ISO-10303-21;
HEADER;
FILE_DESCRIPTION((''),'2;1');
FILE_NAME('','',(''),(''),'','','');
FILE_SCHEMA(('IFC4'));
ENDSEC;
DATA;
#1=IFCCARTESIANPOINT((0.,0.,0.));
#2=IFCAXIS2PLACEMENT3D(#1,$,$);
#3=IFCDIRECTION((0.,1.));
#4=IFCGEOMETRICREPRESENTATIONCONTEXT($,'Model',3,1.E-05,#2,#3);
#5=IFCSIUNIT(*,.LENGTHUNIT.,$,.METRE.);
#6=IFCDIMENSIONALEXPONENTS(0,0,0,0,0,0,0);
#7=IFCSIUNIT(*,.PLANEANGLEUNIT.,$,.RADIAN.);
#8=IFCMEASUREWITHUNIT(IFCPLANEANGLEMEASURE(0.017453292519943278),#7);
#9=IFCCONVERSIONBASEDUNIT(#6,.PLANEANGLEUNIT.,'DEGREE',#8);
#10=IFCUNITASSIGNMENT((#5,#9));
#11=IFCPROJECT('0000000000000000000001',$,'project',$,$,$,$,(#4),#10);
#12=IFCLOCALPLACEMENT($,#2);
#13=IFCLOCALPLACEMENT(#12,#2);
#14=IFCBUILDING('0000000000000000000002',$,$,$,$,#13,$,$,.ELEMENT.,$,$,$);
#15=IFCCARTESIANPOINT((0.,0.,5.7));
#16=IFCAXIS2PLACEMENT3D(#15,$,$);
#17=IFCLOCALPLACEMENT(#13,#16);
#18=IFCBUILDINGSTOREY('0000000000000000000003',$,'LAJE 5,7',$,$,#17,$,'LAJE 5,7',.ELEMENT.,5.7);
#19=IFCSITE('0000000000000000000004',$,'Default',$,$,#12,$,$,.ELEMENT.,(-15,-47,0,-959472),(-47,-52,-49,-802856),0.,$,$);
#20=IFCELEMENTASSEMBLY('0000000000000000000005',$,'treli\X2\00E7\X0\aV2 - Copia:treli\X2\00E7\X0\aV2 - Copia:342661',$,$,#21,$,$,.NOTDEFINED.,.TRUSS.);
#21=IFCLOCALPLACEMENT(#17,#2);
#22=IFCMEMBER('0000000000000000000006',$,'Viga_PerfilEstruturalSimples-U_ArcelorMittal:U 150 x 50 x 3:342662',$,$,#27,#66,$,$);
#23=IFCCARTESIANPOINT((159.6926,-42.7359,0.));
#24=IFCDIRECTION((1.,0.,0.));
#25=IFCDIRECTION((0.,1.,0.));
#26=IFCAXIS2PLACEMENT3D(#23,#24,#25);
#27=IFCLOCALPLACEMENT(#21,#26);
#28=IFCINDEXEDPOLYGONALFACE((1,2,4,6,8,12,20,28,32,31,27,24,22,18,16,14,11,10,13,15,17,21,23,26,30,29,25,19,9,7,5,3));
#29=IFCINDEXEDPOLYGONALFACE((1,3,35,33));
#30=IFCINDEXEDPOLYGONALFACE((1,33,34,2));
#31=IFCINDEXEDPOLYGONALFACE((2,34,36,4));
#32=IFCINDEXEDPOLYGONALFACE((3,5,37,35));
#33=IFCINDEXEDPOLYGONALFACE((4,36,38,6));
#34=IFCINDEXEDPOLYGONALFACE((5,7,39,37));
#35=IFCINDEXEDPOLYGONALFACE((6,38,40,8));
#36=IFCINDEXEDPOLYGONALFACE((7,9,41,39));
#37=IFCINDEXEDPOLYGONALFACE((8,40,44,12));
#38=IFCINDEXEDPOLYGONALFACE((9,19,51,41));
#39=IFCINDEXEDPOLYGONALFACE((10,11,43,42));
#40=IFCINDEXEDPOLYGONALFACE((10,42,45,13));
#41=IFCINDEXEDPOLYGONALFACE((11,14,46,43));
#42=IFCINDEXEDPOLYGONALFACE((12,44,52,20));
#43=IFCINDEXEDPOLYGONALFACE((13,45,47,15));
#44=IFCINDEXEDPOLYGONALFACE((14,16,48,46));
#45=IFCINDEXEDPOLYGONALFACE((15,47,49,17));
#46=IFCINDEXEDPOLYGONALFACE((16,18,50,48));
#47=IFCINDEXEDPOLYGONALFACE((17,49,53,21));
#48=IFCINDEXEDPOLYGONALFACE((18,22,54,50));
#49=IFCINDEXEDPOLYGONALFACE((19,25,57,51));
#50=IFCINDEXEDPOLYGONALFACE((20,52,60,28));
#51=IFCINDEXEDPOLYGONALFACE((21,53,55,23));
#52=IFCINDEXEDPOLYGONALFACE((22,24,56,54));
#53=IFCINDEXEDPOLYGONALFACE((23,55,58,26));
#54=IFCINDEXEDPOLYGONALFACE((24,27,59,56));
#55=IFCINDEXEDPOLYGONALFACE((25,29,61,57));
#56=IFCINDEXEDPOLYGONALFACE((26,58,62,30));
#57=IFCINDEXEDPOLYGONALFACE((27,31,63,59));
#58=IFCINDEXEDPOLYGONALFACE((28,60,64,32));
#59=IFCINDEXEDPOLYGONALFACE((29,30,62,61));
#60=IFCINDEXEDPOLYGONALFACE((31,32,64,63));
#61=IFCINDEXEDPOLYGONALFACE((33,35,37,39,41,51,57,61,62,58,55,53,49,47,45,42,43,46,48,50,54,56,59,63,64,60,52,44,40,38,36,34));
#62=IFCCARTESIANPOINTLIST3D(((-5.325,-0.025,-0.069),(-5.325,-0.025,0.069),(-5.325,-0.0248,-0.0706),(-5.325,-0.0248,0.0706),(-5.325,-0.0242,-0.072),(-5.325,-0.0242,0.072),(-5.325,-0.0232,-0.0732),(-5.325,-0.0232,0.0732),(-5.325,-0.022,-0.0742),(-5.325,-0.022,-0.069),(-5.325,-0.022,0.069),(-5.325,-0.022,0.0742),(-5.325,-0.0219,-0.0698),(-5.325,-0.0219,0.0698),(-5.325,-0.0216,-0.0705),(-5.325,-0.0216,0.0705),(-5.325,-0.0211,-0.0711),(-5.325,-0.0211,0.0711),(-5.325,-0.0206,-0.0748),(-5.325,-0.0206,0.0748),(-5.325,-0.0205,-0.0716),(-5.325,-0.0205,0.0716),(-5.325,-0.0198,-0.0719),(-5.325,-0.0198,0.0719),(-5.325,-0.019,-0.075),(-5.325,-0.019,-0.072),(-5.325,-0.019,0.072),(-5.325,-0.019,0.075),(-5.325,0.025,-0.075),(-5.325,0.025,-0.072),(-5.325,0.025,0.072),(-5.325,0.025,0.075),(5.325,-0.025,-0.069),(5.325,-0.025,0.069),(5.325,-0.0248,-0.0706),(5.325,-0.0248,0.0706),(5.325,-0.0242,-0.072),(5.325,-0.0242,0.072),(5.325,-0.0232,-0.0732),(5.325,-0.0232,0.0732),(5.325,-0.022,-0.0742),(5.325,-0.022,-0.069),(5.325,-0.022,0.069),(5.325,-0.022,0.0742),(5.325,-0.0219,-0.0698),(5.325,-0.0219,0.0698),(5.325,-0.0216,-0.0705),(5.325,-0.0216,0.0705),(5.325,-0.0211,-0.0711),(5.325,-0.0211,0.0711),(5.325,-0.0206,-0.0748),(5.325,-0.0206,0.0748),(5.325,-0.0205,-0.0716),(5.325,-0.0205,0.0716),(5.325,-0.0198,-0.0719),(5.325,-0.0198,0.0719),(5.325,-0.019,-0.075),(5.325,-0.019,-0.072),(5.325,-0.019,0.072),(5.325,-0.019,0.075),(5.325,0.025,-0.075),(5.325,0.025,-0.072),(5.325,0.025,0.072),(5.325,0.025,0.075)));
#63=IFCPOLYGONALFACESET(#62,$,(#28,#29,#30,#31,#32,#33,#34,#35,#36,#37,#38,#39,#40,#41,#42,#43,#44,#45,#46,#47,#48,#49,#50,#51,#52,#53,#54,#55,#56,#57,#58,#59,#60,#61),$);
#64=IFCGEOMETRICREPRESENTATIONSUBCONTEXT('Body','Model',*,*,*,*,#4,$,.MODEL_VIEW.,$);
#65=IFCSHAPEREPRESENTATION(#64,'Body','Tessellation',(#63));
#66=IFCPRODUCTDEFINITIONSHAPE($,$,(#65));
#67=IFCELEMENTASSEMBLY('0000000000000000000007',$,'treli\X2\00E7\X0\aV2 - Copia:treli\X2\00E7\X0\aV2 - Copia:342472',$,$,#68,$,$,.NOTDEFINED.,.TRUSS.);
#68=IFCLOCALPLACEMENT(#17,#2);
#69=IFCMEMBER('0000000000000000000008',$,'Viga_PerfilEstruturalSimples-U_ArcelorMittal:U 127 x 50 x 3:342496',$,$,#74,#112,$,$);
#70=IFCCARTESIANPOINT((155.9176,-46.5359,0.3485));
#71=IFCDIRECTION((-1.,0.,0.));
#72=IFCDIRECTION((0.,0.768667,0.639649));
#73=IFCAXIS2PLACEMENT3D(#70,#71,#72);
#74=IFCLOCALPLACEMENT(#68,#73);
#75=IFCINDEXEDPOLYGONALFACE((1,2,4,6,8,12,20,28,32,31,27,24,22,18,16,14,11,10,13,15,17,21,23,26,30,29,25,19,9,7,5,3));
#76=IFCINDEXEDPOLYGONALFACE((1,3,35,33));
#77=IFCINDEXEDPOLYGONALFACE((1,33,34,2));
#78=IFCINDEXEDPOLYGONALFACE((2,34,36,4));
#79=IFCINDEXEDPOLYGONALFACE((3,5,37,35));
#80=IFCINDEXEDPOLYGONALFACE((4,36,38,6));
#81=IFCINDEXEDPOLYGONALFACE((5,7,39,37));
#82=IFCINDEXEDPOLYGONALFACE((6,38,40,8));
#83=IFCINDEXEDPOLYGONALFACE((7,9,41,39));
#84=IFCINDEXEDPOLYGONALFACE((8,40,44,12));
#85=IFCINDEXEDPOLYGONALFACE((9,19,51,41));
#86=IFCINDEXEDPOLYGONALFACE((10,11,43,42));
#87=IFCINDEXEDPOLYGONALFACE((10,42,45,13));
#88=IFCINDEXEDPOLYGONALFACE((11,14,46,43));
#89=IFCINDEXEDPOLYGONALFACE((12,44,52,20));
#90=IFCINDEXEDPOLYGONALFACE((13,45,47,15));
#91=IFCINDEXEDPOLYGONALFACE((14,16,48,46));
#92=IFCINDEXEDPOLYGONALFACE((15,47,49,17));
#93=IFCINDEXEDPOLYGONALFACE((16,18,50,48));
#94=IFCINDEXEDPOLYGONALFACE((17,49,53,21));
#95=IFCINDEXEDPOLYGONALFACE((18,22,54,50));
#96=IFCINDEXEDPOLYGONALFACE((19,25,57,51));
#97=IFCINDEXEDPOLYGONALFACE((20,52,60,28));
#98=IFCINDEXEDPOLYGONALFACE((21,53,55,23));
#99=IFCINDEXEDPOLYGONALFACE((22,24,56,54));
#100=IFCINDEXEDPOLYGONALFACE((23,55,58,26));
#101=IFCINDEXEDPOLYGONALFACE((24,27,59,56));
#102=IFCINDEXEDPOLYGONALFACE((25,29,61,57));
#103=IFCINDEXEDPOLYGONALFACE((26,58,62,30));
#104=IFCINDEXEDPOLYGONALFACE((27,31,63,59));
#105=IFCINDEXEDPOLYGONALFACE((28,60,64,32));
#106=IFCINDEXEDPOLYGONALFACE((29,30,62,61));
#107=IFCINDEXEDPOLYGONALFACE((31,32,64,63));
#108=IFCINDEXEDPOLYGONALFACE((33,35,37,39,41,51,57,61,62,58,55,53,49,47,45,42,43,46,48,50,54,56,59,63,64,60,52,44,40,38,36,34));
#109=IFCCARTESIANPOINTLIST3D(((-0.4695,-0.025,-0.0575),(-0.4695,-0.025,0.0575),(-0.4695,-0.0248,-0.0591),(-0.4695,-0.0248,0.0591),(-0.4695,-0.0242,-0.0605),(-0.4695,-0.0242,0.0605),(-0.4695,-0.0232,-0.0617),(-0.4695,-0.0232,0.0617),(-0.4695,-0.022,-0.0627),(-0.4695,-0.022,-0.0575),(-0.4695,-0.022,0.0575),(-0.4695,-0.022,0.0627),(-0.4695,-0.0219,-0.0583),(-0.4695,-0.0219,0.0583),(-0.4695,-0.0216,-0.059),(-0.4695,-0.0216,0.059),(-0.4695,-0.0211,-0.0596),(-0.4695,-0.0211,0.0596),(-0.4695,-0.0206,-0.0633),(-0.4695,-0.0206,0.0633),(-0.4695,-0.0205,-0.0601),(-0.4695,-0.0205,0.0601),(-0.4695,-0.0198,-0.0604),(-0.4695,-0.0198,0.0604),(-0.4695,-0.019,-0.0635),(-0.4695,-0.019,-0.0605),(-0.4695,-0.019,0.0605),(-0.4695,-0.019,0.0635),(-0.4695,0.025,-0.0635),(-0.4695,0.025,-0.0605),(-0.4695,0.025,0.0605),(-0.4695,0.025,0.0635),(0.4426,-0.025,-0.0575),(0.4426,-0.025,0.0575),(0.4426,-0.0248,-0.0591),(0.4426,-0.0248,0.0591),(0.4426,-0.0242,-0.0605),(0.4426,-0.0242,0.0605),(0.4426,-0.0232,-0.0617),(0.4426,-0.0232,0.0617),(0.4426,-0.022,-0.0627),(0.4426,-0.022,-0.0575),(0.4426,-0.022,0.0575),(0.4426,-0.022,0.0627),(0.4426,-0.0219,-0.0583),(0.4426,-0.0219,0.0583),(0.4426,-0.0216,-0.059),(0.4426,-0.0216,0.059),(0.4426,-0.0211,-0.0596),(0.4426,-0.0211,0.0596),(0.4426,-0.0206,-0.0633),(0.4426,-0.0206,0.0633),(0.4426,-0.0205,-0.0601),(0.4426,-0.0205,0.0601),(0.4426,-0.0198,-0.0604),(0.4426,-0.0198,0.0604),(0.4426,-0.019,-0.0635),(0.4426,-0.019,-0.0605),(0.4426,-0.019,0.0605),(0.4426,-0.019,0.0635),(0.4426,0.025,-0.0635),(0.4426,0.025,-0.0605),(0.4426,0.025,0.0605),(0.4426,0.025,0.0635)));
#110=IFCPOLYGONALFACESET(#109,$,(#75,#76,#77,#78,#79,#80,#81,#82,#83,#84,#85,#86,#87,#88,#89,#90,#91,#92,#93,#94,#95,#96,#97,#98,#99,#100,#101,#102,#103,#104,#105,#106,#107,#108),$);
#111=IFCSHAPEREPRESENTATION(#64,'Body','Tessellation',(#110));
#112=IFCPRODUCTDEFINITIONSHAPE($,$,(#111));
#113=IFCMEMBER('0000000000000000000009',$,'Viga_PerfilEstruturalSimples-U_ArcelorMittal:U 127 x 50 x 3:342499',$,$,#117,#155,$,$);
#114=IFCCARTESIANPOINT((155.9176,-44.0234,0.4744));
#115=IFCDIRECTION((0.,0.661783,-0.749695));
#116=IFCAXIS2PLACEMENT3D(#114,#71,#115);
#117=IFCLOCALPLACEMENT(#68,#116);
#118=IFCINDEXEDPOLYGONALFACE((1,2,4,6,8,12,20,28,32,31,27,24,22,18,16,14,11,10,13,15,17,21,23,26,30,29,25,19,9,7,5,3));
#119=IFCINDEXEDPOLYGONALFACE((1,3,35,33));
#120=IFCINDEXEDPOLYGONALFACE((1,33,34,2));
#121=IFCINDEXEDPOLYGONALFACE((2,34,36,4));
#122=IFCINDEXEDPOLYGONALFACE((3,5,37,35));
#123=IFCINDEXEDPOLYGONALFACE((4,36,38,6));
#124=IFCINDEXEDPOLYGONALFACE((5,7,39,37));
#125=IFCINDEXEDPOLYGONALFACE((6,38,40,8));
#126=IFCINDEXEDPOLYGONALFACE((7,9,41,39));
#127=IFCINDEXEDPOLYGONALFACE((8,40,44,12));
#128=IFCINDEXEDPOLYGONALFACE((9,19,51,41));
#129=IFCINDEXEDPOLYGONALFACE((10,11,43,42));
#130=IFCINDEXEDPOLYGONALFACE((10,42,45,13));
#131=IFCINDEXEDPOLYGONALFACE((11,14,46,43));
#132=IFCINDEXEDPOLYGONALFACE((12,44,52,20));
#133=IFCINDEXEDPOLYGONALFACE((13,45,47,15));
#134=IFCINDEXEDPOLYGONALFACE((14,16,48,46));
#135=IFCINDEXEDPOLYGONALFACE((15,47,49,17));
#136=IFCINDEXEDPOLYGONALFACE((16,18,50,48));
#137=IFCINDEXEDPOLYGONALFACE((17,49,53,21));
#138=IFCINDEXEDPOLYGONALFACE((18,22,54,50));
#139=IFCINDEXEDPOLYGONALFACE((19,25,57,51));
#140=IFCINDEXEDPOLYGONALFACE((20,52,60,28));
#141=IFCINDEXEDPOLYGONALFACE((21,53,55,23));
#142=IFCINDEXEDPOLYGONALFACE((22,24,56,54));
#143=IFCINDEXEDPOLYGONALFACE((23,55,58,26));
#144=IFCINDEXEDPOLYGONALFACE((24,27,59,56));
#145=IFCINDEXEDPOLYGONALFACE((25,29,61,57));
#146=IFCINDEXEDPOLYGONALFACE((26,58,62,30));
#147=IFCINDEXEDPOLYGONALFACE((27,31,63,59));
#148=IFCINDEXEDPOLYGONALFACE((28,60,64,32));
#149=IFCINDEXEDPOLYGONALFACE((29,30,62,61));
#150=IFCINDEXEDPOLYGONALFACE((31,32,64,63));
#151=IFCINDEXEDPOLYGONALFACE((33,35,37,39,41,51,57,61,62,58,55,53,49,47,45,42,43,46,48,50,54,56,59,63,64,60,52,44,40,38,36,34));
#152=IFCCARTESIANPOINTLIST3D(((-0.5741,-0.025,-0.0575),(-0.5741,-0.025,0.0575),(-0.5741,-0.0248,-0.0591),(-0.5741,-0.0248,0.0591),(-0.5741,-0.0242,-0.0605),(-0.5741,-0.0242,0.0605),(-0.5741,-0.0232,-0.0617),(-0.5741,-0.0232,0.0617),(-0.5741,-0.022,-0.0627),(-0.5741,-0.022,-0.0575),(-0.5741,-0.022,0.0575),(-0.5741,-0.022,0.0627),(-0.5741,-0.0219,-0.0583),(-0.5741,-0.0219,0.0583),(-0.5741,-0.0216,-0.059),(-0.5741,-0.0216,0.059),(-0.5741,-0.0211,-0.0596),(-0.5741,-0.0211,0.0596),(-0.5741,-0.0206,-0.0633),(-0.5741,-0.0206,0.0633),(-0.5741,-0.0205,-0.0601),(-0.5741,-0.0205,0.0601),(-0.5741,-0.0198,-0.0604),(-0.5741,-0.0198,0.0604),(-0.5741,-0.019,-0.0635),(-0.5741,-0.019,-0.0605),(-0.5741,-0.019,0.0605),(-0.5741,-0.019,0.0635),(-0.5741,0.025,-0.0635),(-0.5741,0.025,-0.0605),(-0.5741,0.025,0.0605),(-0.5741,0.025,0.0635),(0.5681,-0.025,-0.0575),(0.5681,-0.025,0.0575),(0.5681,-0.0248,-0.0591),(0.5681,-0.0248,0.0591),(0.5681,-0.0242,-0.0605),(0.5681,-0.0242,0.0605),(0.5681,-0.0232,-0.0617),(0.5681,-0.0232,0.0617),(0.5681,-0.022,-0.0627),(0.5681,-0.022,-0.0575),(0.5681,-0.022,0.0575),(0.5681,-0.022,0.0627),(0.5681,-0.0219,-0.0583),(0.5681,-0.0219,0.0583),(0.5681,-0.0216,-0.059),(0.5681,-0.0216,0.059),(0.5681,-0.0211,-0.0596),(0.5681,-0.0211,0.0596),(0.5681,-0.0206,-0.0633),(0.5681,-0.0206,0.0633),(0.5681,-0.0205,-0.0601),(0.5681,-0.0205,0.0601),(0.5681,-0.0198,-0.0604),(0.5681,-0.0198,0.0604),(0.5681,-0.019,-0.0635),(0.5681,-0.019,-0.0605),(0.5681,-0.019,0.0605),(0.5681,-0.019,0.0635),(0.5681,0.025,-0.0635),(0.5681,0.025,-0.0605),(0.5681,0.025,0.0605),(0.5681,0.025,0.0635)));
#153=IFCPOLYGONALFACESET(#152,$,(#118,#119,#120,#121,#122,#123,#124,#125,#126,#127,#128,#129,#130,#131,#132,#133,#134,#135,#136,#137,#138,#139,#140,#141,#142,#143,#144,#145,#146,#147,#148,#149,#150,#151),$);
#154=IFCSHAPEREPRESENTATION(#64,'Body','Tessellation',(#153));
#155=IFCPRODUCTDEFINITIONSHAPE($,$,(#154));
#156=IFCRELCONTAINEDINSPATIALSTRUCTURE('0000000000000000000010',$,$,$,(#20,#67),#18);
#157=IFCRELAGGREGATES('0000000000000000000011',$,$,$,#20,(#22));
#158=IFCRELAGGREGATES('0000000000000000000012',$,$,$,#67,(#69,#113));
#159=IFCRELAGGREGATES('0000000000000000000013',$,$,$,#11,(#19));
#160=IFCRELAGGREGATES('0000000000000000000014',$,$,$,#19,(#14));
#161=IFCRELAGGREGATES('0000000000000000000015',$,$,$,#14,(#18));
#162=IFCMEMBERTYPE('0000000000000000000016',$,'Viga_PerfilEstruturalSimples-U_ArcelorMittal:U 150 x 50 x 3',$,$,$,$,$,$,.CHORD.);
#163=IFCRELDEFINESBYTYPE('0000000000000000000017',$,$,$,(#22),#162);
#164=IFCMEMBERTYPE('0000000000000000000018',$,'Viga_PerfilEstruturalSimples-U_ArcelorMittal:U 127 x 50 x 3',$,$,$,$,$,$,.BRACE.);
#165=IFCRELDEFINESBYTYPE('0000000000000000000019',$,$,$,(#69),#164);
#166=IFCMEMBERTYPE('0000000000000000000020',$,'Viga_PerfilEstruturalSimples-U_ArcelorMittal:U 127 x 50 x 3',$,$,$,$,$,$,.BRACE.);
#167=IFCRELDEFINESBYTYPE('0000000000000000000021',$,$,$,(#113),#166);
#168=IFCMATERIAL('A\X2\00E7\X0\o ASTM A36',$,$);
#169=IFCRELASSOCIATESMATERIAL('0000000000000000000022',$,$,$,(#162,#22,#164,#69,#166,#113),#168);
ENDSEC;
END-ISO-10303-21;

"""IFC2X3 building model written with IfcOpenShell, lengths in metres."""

from ifc_helpers import new_model, entity, si_unit, converted_unit, direction, frame, frame_2d, origin, place, context, subcontext, project, spatial, polyline, circle_curve, parameter, trimmed, segment, composite_curve, outline, extrude, source, transform, mapped, material, type_object, type_shapes, element, aggregate, save


model = new_model("IFC2X3")

# Units and contexts
model_context = context("Model", 3, precision=1e-05, world=origin(), true_north=direction((0.0, 1.0)))
body_context = subcontext(model_context, "Body", "Model", "MODEL_VIEW")
ifc_project = project(units=[si_unit("LENGTHUNIT", "METRE"), converted_unit("PLANEANGLEUNIT", "DEGREE", entity("IfcPlaneAngleMeasure", 0.017453292519943278), si_unit("PLANEANGLEUNIT", "RADIAN"), dimensions=[0, 0, 0, 0, 0, 0, 0])], contexts=[model_context])

# Site, building, storey
site_placement = place(None, origin())
site = spatial("IfcSite", under=ifc_project, at=site_placement, Name="Default", CompositionType="ELEMENT", RefLatitude=(-15, -47, 0, -959472), RefLongitude=(-47, -52, -49, -802856), RefElevation=0.0)
building_placement = place(site_placement, origin())
building = spatial("IfcBuilding", under=site, at=building_placement, CompositionType="ELEMENT")
storey_placement = place(building_placement, frame((0.0, 0.0, 5.7)))
storey = spatial("IfcBuildingStorey", under=building, at=storey_placement, Name="LAJE 5,7", LongName="LAJE 5,7", CompositionType="ELEMENT", Elevation=5.7)

# Element assemblies, members
assembly_1_placement = place(storey_placement, origin())
assembly_1 = element("IfcElementAssembly", 1, at=assembly_1_placement, inside=storey, Name="treliçaV2 - Copia:treliçaV2 - Copia:342661", AssemblyPlace="NOTDEFINED", PredefinedType="TRUSS")
ifc_material = material(Name="Aço ASTM A36")
member_type_1 = type_object("IfcMemberType", Name="Viga_PerfilEstruturalSimples-U_ArcelorMittal:U 150 x 50 x 3", PredefinedType="CHORD", material=ifc_material)
shared_shape_1 = source(origin(), body_context, "Body", "SweptSolid", [
    extrude(outline(composite_curve([segment(polyline([(-0.069, -0.0192), (0.069, -0.0192)]), True, "CONTINUOUS"), segment(trimmed(circle_curve(frame_2d((0.069, -0.0132), x_axis=(0.0, 1.0)), 0.006), [parameter(180.0)], [parameter(270.0)], True, "PARAMETER"), True, "CONTINUOUS"), segment(polyline([(0.075, -0.0132), (0.075, 0.0308)]), True, "CONTINUOUS"), segment(polyline([(0.075, 0.0308), (0.072, 0.0308)]), True, "CONTINUOUS"), segment(polyline([(0.072, 0.0308), (0.072, -0.0132)]), True, "CONTINUOUS"), segment(trimmed(circle_curve(frame_2d((0.069, -0.0132), x_axis=(0.0, 1.0)), 0.003), [parameter(180.0)], [parameter(270.0)], True, "PARAMETER"), False, "CONTINUOUS"), segment(polyline([(0.069, -0.0162), (-0.069, -0.0162)]), True, "CONTINUOUS"), segment(trimmed(circle_curve(frame_2d((-0.069, -0.0132), x_axis=(0.0, 1.0)), 0.003), [parameter(90.0)], [parameter(180.0)], True, "PARAMETER"), False, "CONTINUOUS"), segment(polyline([(-0.072, -0.0132), (-0.072, 0.0308)]), True, "CONTINUOUS"), segment(polyline([(-0.072, 0.0308), (-0.075, 0.0308)]), True, "CONTINUOUS"), segment(polyline([(-0.075, 0.0308), (-0.075, -0.0132)]), True, "CONTINUOUS"), segment(trimmed(circle_curve(frame_2d((-0.069, -0.0132), x_axis=(0.0, 1.0)), 0.006), [parameter(90.0)], [parameter(180.0)], True, "PARAMETER"), True, "CONTINUOUS")], self_intersect=False)), frame((-5.325, -0.0058, 0.0), z_axis=(1.0, 0.0, 0.0), x_axis=(0.0, 0.0, -1.0)), (0.0, 0.0, 1.0), 10.65),
])
type_shapes(member_type_1, [shared_shape_1])
member_1_placement = place(assembly_1_placement, frame((159.6926, -42.7359, 0.0), z_axis=(1.0, 0.0, 0.0), x_axis=(0.0, 1.0, 0.0)))
member_1 = element("IfcMember", 2, at=member_1_placement, type_object=member_type_1, material=ifc_material, Name="Viga_PerfilEstruturalSimples-U_ArcelorMittal:U 150 x 50 x 3:342662", context=body_context, shape_type="MappedRepresentation", body=[
    mapped(shared_shape_1, transform((0.0, 0.0, 0.0), scale=1.0)),
])
aggregate(assembly_1, [member_1])
assembly_2_placement = place(storey_placement, origin())
assembly_2 = element("IfcElementAssembly", 3, at=assembly_2_placement, inside=storey, Name="treliçaV2 - Copia:treliçaV2 - Copia:342472", AssemblyPlace="NOTDEFINED", PredefinedType="TRUSS")
member_type_2 = type_object("IfcMemberType", Name="Viga_PerfilEstruturalSimples-U_ArcelorMittal:U 127 x 50 x 3", PredefinedType="BRACE", material=ifc_material)
shared_shape_2 = source(origin(), body_context, "Body", "SweptSolid", [
    extrude(outline(composite_curve([segment(polyline([(-0.0575, -0.0192), (0.0575, -0.0192)]), True, "CONTINUOUS"), segment(trimmed(circle_curve(frame_2d((0.0575, -0.0132), x_axis=(0.0, 1.0)), 0.006), [parameter(180.0)], [parameter(270.0)], True, "PARAMETER"), True, "CONTINUOUS"), segment(polyline([(0.0635, -0.0132), (0.0635, 0.0308)]), True, "CONTINUOUS"), segment(polyline([(0.0635, 0.0308), (0.0605, 0.0308)]), True, "CONTINUOUS"), segment(polyline([(0.0605, 0.0308), (0.0605, -0.0132)]), True, "CONTINUOUS"), segment(trimmed(circle_curve(frame_2d((0.0575, -0.0132), x_axis=(0.0, 1.0)), 0.003), [parameter(180.0)], [parameter(270.0)], True, "PARAMETER"), False, "CONTINUOUS"), segment(polyline([(0.0575, -0.0162), (-0.0575, -0.0162)]), True, "CONTINUOUS"), segment(trimmed(circle_curve(frame_2d((-0.0575, -0.0132), x_axis=(0.0, 1.0)), 0.003), [parameter(90.0)], [parameter(180.0)], True, "PARAMETER"), False, "CONTINUOUS"), segment(polyline([(-0.0605, -0.0132), (-0.0605, 0.0308)]), True, "CONTINUOUS"), segment(polyline([(-0.0605, 0.0308), (-0.0635, 0.0308)]), True, "CONTINUOUS"), segment(polyline([(-0.0635, 0.0308), (-0.0635, -0.0132)]), True, "CONTINUOUS"), segment(trimmed(circle_curve(frame_2d((-0.0575, -0.0132), x_axis=(0.0, 1.0)), 0.006), [parameter(90.0)], [parameter(180.0)], True, "PARAMETER"), True, "CONTINUOUS")], self_intersect=False)), frame((-0.4695, -0.0058, 0.0), z_axis=(1.0, 0.0, 0.0), x_axis=(0.0, 0.0, -1.0)), (0.0, 0.0, 1.0), 0.9121),
])
type_shapes(member_type_2, [shared_shape_2])
member_2_placement = place(assembly_2_placement, frame((155.9176, -46.5359, 0.3485), z_axis=(-1.0, 0.0, 0.0), x_axis=(0.0, 0.768667, 0.639649)))
member_2 = element("IfcMember", 4, at=member_2_placement, type_object=member_type_2, material=ifc_material, Name="Viga_PerfilEstruturalSimples-U_ArcelorMittal:U 127 x 50 x 3:342496", context=body_context, shape_type="MappedRepresentation", body=[
    mapped(shared_shape_2, transform((0.0, 0.0, 0.0), scale=1.0)),
])
member_type_3 = type_object("IfcMemberType", Name="Viga_PerfilEstruturalSimples-U_ArcelorMittal:U 127 x 50 x 3", PredefinedType="BRACE", material=ifc_material)
shared_shape_3 = source(origin(), body_context, "Body", "SweptSolid", [
    extrude(outline(composite_curve([segment(polyline([(-0.0575, -0.0192), (0.0575, -0.0192)]), True, "CONTINUOUS"), segment(trimmed(circle_curve(frame_2d((0.0575, -0.0132), x_axis=(0.0, 1.0)), 0.006), [parameter(180.0)], [parameter(270.0)], True, "PARAMETER"), True, "CONTINUOUS"), segment(polyline([(0.0635, -0.0132), (0.0635, 0.0308)]), True, "CONTINUOUS"), segment(polyline([(0.0635, 0.0308), (0.0605, 0.0308)]), True, "CONTINUOUS"), segment(polyline([(0.0605, 0.0308), (0.0605, -0.0132)]), True, "CONTINUOUS"), segment(trimmed(circle_curve(frame_2d((0.0575, -0.0132), x_axis=(0.0, 1.0)), 0.003), [parameter(180.0)], [parameter(270.0)], True, "PARAMETER"), False, "CONTINUOUS"), segment(polyline([(0.0575, -0.0162), (-0.0575, -0.0162)]), True, "CONTINUOUS"), segment(trimmed(circle_curve(frame_2d((-0.0575, -0.0132), x_axis=(0.0, 1.0)), 0.003), [parameter(90.0)], [parameter(180.0)], True, "PARAMETER"), False, "CONTINUOUS"), segment(polyline([(-0.0605, -0.0132), (-0.0605, 0.0308)]), True, "CONTINUOUS"), segment(polyline([(-0.0605, 0.0308), (-0.0635, 0.0308)]), True, "CONTINUOUS"), segment(polyline([(-0.0635, 0.0308), (-0.0635, -0.0132)]), True, "CONTINUOUS"), segment(trimmed(circle_curve(frame_2d((-0.0575, -0.0132), x_axis=(0.0, 1.0)), 0.006), [parameter(90.0)], [parameter(180.0)], True, "PARAMETER"), True, "CONTINUOUS")], self_intersect=False)), frame((-0.5741, -0.0058, 0.0), z_axis=(1.0, 0.0, 0.0), x_axis=(0.0, 0.0, -1.0)), (0.0, 0.0, 1.0), 1.1422),
])
type_shapes(member_type_3, [shared_shape_3])
member_3_placement = place(assembly_2_placement, frame((155.9176, -44.0234, 0.4744), z_axis=(-1.0, 0.0, 0.0), x_axis=(0.0, 0.661783, -0.749695)))
member_3 = element("IfcMember", 5, at=member_3_placement, type_object=member_type_3, material=ifc_material, Name="Viga_PerfilEstruturalSimples-U_ArcelorMittal:U 127 x 50 x 3:342499", context=body_context, shape_type="MappedRepresentation", body=[
    mapped(shared_shape_3, transform((0.0, 0.0, 0.0), scale=1.0)),
])
aggregate(assembly_2, [member_2, member_3])

save(model, "model.ifc")
